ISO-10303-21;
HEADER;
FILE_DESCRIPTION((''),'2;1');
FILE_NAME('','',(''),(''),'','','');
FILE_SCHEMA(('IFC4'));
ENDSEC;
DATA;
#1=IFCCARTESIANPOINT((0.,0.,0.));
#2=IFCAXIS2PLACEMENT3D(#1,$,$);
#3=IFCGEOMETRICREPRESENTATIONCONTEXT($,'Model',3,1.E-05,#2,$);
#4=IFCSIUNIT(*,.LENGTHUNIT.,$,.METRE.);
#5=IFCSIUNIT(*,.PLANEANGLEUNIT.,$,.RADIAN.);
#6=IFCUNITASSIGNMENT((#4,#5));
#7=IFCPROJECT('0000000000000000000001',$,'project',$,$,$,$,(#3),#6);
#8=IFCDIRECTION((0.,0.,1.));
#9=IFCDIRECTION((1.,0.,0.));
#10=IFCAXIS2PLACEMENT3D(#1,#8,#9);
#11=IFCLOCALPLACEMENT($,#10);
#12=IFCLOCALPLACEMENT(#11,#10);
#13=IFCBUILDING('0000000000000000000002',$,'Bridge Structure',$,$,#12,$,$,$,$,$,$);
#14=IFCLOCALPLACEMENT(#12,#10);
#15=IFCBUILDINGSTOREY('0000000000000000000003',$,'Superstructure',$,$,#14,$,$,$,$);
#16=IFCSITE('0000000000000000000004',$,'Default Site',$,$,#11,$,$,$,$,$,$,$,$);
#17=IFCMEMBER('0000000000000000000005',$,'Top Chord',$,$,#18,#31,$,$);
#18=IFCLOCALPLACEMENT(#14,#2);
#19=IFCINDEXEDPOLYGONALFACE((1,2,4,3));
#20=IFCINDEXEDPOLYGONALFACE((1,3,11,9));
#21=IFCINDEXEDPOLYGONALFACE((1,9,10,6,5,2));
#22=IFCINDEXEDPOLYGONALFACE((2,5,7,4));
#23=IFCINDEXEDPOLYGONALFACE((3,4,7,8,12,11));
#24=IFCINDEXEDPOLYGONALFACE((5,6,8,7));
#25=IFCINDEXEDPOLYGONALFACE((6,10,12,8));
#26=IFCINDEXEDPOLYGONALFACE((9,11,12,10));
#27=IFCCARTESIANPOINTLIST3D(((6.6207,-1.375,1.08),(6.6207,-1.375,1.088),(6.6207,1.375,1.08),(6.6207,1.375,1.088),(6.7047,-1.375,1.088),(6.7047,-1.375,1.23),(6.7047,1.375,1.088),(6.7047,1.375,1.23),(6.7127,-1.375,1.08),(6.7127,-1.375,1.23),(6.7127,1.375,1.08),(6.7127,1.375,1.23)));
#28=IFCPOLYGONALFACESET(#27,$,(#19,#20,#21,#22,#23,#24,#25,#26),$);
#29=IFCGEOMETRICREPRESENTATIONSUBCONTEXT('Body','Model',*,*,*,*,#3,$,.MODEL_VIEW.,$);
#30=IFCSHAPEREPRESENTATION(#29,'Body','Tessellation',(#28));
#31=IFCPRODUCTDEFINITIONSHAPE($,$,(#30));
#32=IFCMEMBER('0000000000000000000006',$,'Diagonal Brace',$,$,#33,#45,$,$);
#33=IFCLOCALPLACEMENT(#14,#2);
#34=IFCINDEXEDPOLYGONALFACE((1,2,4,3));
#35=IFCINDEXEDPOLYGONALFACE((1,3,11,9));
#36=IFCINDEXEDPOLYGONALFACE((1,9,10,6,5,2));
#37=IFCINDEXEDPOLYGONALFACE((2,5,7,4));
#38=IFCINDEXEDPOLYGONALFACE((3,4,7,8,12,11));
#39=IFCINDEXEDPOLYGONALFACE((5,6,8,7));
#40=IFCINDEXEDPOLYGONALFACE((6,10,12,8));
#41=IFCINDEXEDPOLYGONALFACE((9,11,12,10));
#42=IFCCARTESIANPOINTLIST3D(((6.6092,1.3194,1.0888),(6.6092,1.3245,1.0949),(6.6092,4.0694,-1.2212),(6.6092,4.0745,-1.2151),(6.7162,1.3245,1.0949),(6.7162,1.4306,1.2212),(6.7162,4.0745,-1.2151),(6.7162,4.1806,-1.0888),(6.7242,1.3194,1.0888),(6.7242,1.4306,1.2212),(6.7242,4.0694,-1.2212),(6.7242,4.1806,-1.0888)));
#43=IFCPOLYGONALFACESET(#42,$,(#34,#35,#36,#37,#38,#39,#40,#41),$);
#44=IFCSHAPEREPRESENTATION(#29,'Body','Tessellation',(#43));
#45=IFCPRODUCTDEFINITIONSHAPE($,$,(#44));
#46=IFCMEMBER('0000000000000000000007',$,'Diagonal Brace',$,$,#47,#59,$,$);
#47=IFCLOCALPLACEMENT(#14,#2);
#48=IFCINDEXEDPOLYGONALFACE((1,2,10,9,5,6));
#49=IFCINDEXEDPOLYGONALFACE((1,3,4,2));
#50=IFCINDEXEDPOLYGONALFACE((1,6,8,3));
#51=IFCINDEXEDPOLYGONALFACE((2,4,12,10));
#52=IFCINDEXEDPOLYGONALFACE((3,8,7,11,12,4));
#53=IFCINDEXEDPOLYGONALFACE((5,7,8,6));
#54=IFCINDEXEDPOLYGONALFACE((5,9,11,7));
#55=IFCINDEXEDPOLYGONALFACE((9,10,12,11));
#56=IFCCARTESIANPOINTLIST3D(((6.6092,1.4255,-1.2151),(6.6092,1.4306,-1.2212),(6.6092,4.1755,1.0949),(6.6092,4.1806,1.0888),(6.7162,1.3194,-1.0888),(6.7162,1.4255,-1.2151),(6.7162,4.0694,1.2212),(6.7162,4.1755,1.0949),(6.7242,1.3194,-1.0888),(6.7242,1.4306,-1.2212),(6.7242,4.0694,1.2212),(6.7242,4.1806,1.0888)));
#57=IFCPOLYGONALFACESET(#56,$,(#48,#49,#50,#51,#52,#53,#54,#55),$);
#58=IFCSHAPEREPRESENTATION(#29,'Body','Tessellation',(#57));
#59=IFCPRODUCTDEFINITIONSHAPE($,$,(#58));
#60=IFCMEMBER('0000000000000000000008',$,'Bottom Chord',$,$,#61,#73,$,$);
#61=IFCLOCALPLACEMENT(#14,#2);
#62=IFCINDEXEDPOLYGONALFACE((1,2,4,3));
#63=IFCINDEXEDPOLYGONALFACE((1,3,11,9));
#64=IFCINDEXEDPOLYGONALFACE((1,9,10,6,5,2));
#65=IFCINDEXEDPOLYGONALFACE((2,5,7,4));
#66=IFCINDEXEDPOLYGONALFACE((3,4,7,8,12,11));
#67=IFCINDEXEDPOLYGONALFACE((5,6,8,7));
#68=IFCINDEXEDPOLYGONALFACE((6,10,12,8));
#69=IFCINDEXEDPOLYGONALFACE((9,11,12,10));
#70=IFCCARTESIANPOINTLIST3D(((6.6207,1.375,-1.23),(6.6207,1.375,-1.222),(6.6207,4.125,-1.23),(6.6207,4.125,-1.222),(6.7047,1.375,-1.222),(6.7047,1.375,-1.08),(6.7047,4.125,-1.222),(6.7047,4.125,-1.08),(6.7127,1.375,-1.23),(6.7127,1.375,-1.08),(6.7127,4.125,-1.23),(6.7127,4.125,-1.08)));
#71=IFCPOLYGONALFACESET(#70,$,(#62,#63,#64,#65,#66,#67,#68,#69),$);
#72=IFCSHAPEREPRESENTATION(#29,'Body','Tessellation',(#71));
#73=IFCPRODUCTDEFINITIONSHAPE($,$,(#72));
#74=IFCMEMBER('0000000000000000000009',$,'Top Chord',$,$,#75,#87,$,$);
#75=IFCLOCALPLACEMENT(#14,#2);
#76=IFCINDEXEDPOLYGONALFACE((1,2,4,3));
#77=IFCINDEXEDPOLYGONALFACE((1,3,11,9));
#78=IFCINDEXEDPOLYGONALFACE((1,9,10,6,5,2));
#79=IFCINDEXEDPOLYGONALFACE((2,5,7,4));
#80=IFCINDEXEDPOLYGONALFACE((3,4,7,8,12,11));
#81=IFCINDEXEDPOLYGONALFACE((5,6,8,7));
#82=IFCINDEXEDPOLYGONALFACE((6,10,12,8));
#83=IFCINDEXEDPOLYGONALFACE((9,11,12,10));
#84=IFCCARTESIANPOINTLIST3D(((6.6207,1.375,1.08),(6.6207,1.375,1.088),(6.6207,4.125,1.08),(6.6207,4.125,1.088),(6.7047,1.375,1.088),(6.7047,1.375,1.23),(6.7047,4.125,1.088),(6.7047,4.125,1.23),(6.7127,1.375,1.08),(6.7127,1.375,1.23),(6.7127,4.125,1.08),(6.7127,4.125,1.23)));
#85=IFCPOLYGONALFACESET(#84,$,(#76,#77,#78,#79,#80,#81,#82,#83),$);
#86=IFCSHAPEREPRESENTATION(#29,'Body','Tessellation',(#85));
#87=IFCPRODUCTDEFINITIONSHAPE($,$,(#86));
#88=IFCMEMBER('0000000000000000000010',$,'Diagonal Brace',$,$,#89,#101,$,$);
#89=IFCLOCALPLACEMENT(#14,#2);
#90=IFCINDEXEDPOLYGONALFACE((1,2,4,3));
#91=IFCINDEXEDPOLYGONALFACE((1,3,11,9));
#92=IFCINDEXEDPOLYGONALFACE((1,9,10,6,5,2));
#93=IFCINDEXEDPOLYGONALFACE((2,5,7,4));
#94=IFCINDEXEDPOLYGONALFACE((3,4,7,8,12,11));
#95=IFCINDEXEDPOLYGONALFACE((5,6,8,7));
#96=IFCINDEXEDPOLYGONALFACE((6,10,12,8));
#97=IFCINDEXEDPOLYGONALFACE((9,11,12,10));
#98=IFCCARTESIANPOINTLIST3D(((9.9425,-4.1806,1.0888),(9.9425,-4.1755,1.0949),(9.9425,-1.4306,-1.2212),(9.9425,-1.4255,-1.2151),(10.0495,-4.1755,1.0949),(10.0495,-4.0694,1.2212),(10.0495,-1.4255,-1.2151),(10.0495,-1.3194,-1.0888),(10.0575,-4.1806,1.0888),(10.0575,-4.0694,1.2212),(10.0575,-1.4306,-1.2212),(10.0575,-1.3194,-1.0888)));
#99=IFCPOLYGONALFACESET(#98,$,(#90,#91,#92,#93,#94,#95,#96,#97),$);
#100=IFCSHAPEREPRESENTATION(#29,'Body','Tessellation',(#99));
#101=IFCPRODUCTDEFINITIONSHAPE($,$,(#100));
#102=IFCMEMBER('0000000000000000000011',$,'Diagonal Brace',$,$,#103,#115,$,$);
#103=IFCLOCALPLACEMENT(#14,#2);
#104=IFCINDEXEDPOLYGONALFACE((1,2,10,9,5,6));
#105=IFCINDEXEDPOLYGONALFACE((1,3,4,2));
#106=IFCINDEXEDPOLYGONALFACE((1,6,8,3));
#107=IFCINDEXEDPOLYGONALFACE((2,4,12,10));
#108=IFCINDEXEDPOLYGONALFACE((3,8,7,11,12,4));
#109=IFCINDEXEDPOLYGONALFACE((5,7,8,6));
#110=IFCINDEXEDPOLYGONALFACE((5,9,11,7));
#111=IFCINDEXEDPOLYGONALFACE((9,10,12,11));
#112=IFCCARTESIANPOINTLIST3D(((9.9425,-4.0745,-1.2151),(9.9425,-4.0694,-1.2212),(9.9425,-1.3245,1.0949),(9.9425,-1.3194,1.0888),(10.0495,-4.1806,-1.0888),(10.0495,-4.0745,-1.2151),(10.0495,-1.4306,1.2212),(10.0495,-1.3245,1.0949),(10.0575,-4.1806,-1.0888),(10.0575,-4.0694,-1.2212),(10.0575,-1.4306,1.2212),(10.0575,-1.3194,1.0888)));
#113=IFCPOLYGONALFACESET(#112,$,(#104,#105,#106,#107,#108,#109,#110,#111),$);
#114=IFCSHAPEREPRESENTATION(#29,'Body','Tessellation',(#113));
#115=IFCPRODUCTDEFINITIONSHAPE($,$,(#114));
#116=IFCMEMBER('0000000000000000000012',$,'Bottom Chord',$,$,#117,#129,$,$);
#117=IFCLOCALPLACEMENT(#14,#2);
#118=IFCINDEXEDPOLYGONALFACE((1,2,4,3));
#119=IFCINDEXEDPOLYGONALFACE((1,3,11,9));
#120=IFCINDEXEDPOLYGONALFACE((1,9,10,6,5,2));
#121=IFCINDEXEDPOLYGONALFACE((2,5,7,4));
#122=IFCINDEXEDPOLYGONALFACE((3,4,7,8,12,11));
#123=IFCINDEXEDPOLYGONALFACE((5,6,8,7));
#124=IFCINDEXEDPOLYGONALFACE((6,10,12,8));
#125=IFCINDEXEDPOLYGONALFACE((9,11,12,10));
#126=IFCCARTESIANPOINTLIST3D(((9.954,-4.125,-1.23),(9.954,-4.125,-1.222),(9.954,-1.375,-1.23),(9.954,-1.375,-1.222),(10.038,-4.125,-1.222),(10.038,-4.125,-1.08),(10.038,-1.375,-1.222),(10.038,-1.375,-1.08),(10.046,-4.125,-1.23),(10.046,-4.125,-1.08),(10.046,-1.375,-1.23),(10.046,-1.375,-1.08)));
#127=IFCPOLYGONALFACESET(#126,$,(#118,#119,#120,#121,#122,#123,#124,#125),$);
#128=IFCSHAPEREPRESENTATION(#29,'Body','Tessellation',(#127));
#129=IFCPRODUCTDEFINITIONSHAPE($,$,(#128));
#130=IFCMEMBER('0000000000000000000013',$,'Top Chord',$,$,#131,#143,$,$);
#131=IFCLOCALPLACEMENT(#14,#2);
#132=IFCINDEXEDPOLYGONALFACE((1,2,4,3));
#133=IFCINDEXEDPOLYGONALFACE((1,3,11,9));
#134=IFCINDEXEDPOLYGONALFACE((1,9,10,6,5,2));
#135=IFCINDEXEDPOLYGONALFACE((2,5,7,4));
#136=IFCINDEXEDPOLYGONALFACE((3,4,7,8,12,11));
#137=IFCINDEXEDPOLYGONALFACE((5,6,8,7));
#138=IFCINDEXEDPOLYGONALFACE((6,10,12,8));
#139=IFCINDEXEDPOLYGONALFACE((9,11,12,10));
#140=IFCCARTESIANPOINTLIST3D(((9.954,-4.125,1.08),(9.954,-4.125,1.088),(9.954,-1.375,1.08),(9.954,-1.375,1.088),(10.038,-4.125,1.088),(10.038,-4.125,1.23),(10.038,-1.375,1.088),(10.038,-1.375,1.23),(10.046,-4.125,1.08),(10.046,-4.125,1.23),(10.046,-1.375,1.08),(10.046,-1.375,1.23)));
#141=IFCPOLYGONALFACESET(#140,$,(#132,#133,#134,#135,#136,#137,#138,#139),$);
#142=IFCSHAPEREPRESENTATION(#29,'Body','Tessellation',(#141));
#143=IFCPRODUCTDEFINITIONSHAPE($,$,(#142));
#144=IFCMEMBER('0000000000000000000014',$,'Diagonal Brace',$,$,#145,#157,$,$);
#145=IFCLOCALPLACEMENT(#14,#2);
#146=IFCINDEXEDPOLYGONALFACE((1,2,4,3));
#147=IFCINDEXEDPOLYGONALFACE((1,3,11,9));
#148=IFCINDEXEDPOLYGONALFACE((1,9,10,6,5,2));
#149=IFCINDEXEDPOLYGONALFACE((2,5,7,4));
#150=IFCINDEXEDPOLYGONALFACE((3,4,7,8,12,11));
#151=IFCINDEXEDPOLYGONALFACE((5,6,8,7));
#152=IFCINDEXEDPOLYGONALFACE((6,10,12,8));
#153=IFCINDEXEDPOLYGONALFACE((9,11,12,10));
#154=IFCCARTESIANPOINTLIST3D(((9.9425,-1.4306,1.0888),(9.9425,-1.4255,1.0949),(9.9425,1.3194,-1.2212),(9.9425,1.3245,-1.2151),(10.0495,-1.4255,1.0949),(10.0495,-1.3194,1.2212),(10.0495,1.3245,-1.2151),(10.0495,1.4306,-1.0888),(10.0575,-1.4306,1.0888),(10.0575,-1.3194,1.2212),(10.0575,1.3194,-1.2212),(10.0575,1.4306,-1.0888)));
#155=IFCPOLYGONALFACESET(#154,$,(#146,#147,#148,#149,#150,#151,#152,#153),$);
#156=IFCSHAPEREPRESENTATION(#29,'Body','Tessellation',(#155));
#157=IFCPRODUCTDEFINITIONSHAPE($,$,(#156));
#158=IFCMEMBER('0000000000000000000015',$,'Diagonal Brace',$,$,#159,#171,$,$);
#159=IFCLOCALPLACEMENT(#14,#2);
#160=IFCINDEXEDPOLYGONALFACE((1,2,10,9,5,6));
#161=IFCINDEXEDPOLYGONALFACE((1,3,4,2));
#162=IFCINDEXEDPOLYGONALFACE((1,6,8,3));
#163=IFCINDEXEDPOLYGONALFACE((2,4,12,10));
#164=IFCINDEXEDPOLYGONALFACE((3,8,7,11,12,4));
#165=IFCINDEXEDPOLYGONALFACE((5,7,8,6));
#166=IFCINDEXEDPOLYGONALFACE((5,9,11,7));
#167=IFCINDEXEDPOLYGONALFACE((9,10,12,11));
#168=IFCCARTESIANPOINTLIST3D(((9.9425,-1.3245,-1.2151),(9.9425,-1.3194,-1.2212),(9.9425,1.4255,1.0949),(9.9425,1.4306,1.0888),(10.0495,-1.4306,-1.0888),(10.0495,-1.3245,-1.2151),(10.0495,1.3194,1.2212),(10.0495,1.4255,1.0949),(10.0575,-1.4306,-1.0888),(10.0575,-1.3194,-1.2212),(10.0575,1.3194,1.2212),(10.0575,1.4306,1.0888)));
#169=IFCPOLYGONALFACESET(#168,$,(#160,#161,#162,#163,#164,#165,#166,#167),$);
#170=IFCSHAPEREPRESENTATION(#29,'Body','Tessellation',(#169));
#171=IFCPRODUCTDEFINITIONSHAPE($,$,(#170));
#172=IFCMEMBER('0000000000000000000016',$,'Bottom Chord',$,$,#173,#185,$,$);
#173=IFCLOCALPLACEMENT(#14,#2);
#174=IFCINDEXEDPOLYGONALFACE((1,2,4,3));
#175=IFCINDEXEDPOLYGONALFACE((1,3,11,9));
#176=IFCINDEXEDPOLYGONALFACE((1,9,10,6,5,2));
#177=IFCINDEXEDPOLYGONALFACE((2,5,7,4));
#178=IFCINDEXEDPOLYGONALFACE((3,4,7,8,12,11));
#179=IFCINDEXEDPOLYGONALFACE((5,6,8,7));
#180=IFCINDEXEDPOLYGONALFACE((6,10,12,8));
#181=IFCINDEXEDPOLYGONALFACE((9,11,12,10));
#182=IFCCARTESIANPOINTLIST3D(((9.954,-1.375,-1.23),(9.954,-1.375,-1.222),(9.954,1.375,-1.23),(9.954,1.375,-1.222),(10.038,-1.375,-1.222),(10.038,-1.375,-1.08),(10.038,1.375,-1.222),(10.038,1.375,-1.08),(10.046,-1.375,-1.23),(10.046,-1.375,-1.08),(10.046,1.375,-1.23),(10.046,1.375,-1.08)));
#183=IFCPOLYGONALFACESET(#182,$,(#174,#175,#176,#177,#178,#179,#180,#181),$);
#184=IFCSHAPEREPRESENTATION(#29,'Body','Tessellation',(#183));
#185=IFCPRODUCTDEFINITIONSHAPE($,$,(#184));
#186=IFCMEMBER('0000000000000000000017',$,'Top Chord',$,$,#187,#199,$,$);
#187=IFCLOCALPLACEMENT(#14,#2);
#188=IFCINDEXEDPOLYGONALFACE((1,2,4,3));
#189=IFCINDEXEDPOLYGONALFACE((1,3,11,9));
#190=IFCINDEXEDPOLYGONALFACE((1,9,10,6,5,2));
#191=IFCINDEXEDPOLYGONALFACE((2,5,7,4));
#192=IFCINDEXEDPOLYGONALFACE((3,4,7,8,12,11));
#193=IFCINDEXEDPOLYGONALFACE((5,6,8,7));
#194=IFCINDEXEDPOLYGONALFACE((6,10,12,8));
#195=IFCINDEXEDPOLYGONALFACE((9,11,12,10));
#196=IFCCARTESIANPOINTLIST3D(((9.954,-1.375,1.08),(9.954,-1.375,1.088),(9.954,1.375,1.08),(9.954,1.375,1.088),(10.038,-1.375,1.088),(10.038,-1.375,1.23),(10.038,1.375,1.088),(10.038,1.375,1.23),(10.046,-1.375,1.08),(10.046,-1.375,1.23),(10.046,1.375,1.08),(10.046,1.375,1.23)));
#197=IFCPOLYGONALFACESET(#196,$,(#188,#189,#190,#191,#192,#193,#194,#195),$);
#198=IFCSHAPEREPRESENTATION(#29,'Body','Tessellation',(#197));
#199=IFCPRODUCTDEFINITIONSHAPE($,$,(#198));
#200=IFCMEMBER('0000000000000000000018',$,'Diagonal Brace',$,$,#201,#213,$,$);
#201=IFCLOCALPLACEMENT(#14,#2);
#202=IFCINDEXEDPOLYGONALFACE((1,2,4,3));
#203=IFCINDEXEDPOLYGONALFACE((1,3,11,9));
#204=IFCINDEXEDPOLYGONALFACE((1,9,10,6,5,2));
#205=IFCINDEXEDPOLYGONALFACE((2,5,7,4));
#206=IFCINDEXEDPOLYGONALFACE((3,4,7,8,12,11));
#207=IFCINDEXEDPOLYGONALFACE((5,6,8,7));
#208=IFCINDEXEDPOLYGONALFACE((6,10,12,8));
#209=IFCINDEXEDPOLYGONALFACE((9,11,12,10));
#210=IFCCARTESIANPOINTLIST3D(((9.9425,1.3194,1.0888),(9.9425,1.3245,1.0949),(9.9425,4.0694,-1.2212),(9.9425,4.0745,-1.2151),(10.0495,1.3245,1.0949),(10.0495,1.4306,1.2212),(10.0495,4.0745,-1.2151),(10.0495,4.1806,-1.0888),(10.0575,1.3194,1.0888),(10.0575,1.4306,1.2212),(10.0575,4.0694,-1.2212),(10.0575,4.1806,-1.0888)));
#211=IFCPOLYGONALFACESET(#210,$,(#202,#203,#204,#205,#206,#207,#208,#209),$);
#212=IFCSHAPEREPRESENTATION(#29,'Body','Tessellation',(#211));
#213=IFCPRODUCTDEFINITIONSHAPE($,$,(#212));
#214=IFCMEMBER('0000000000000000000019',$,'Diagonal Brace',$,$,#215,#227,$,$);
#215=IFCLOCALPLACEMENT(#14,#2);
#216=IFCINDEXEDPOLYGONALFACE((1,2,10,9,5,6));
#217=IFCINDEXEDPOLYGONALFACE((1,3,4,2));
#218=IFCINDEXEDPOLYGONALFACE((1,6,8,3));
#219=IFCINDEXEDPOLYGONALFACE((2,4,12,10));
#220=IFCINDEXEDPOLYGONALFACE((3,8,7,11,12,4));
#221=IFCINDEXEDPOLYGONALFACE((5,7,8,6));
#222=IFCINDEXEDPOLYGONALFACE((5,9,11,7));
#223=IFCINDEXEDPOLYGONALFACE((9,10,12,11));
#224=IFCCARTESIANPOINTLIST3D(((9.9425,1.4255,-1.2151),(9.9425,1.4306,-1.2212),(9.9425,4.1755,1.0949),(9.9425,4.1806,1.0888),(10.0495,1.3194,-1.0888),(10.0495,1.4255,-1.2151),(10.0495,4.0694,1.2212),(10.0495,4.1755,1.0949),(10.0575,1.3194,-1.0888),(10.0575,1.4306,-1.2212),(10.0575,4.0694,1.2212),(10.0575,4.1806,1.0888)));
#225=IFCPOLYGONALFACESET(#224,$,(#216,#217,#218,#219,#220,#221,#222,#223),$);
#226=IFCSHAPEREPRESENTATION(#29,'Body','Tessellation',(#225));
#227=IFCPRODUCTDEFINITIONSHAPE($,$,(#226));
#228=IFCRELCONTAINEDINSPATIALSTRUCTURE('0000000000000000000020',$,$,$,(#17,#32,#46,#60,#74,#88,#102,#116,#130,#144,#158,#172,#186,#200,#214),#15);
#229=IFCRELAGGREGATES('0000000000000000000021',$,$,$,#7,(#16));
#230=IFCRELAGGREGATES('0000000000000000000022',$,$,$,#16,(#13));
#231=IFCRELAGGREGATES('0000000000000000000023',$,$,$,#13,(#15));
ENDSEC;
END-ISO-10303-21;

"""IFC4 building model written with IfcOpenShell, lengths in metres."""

from ifc_helpers import new_model, si_unit, frame, origin, origin_with_axes, origin_2d_with_axis, place, context, subcontext, project, spatial, l_section, extrude, element, save


model = new_model("IFC4")

# Units and contexts
model_context = context("Model", 3, precision=1e-05, world=origin())
body_context = subcontext(model_context, "Body", "Model", "MODEL_VIEW")
ifc_project = project(units=[si_unit("LENGTHUNIT", "METRE"), si_unit("PLANEANGLEUNIT", "RADIAN")], contexts=[model_context])

# Site, building, storey
site_placement = place(None, origin_with_axes())
site = spatial("IfcSite", under=ifc_project, at=site_placement, Name="Default Site")
building_placement = place(site_placement, origin_with_axes())
building = spatial("IfcBuilding", under=site, at=building_placement, Name="Bridge Structure")
storey_placement = place(building_placement, origin_with_axes())
storey = spatial("IfcBuildingStorey", under=building, at=storey_placement, Name="Superstructure")

# Members
member_1_placement = place(storey_placement, frame((6.6667, -1.375, 1.155), z_axis=(0.0, 1.0, 0.0), x_axis=(-1.0, 0.0, 0.0)))
element("IfcMember", 1, at=member_1_placement, inside=storey, Name="Top Chord", context=body_context, shape_type="SweptSolid", body=[
    extrude(l_section(Depth=0.15, Width=0.092, Thickness=0.008, at=origin_2d_with_axis()), origin_with_axes(), (0.0, 0.0, 1.0), 2.75),
])
for number, where, z_axis, x_axis, name in (
    (2, (6.6667, 1.375, 1.155), (0.0, 0.765705, -0.643192), (-1.0, 0.0, 0.0), "Diagonal Brace"),
    (3, (6.6667, 1.375, -1.155), (0.0, 0.765705, 0.643192), (-1.0, 0.0, 0.0), "Diagonal Brace"),
):
    element("IfcMember", number, at=place(storey_placement, frame(where, z_axis=z_axis, x_axis=x_axis)), inside=storey, Name=name, context=body_context, shape_type="SweptSolid", body=[
        extrude(l_section(Depth=0.173, Width=0.115, Thickness=0.008, at=origin_2d_with_axis()), origin_with_axes(), (0.0, 0.0, 1.0), 3.5915),
    ])
for number, where, z_axis, x_axis, name in (
    (4, (6.6667, 1.375, -1.155), (0.0, 1.0, 0.0), (-1.0, 0.0, 0.0), "Bottom Chord"),
    (5, (6.6667, 1.375, 1.155), (0.0, 1.0, 0.0), (-1.0, 0.0, 0.0), "Top Chord"),
):
    element("IfcMember", number, at=place(storey_placement, frame(where, z_axis=z_axis, x_axis=x_axis)), inside=storey, Name=name, context=body_context, shape_type="SweptSolid", body=[
        extrude(l_section(Depth=0.15, Width=0.092, Thickness=0.008, at=origin_2d_with_axis()), origin_with_axes(), (0.0, 0.0, 1.0), 2.75),
    ])
for number, where, z_axis, x_axis, name in (
    (6, (10.0, -4.125, 1.155), (0.0, 0.765705, -0.643192), (-1.0, 0.0, 0.0), "Diagonal Brace"),
    (7, (10.0, -4.125, -1.155), (0.0, 0.765705, 0.643192), (-1.0, 0.0, 0.0), "Diagonal Brace"),
):
    element("IfcMember", number, at=place(storey_placement, frame(where, z_axis=z_axis, x_axis=x_axis)), inside=storey, Name=name, context=body_context, shape_type="SweptSolid", body=[
        extrude(l_section(Depth=0.173, Width=0.115, Thickness=0.008, at=origin_2d_with_axis()), origin_with_axes(), (0.0, 0.0, 1.0), 3.5915),
    ])
for number, where, z_axis, x_axis, name in (
    (8, (10.0, -4.125, -1.155), (0.0, 1.0, 0.0), (-1.0, 0.0, 0.0), "Bottom Chord"),
    (9, (10.0, -4.125, 1.155), (0.0, 1.0, 0.0), (-1.0, 0.0, 0.0), "Top Chord"),
):
    element("IfcMember", number, at=place(storey_placement, frame(where, z_axis=z_axis, x_axis=x_axis)), inside=storey, Name=name, context=body_context, shape_type="SweptSolid", body=[
        extrude(l_section(Depth=0.15, Width=0.092, Thickness=0.008, at=origin_2d_with_axis()), origin_with_axes(), (0.0, 0.0, 1.0), 2.75),
    ])
for number, where, z_axis, x_axis, name in (
    (10, (10.0, -1.375, 1.155), (0.0, 0.765705, -0.643192), (-1.0, 0.0, 0.0), "Diagonal Brace"),
    (11, (10.0, -1.375, -1.155), (0.0, 0.765705, 0.643192), (-1.0, 0.0, 0.0), "Diagonal Brace"),
):
    element("IfcMember", number, at=place(storey_placement, frame(where, z_axis=z_axis, x_axis=x_axis)), inside=storey, Name=name, context=body_context, shape_type="SweptSolid", body=[
        extrude(l_section(Depth=0.173, Width=0.115, Thickness=0.008, at=origin_2d_with_axis()), origin_with_axes(), (0.0, 0.0, 1.0), 3.5915),
    ])
for number, where, z_axis, x_axis, name in (
    (12, (10.0, -1.375, -1.155), (0.0, 1.0, 0.0), (-1.0, 0.0, 0.0), "Bottom Chord"),
    (13, (10.0, -1.375, 1.155), (0.0, 1.0, 0.0), (-1.0, 0.0, 0.0), "Top Chord"),
):
    element("IfcMember", number, at=place(storey_placement, frame(where, z_axis=z_axis, x_axis=x_axis)), inside=storey, Name=name, context=body_context, shape_type="SweptSolid", body=[
        extrude(l_section(Depth=0.15, Width=0.092, Thickness=0.008, at=origin_2d_with_axis()), origin_with_axes(), (0.0, 0.0, 1.0), 2.75),
    ])
for number, where, z_axis, x_axis, name in (
    (14, (10.0, 1.375, 1.155), (0.0, 0.765705, -0.643192), (-1.0, 0.0, 0.0), "Diagonal Brace"),
    (15, (10.0, 1.375, -1.155), (0.0, 0.765705, 0.643192), (-1.0, 0.0, 0.0), "Diagonal Brace"),
):
    element("IfcMember", number, at=place(storey_placement, frame(where, z_axis=z_axis, x_axis=x_axis)), inside=storey, Name=name, context=body_context, shape_type="SweptSolid", body=[
        extrude(l_section(Depth=0.173, Width=0.115, Thickness=0.008, at=origin_2d_with_axis()), origin_with_axes(), (0.0, 0.0, 1.0), 3.5915),
    ])

save(model, "model.ifc")
